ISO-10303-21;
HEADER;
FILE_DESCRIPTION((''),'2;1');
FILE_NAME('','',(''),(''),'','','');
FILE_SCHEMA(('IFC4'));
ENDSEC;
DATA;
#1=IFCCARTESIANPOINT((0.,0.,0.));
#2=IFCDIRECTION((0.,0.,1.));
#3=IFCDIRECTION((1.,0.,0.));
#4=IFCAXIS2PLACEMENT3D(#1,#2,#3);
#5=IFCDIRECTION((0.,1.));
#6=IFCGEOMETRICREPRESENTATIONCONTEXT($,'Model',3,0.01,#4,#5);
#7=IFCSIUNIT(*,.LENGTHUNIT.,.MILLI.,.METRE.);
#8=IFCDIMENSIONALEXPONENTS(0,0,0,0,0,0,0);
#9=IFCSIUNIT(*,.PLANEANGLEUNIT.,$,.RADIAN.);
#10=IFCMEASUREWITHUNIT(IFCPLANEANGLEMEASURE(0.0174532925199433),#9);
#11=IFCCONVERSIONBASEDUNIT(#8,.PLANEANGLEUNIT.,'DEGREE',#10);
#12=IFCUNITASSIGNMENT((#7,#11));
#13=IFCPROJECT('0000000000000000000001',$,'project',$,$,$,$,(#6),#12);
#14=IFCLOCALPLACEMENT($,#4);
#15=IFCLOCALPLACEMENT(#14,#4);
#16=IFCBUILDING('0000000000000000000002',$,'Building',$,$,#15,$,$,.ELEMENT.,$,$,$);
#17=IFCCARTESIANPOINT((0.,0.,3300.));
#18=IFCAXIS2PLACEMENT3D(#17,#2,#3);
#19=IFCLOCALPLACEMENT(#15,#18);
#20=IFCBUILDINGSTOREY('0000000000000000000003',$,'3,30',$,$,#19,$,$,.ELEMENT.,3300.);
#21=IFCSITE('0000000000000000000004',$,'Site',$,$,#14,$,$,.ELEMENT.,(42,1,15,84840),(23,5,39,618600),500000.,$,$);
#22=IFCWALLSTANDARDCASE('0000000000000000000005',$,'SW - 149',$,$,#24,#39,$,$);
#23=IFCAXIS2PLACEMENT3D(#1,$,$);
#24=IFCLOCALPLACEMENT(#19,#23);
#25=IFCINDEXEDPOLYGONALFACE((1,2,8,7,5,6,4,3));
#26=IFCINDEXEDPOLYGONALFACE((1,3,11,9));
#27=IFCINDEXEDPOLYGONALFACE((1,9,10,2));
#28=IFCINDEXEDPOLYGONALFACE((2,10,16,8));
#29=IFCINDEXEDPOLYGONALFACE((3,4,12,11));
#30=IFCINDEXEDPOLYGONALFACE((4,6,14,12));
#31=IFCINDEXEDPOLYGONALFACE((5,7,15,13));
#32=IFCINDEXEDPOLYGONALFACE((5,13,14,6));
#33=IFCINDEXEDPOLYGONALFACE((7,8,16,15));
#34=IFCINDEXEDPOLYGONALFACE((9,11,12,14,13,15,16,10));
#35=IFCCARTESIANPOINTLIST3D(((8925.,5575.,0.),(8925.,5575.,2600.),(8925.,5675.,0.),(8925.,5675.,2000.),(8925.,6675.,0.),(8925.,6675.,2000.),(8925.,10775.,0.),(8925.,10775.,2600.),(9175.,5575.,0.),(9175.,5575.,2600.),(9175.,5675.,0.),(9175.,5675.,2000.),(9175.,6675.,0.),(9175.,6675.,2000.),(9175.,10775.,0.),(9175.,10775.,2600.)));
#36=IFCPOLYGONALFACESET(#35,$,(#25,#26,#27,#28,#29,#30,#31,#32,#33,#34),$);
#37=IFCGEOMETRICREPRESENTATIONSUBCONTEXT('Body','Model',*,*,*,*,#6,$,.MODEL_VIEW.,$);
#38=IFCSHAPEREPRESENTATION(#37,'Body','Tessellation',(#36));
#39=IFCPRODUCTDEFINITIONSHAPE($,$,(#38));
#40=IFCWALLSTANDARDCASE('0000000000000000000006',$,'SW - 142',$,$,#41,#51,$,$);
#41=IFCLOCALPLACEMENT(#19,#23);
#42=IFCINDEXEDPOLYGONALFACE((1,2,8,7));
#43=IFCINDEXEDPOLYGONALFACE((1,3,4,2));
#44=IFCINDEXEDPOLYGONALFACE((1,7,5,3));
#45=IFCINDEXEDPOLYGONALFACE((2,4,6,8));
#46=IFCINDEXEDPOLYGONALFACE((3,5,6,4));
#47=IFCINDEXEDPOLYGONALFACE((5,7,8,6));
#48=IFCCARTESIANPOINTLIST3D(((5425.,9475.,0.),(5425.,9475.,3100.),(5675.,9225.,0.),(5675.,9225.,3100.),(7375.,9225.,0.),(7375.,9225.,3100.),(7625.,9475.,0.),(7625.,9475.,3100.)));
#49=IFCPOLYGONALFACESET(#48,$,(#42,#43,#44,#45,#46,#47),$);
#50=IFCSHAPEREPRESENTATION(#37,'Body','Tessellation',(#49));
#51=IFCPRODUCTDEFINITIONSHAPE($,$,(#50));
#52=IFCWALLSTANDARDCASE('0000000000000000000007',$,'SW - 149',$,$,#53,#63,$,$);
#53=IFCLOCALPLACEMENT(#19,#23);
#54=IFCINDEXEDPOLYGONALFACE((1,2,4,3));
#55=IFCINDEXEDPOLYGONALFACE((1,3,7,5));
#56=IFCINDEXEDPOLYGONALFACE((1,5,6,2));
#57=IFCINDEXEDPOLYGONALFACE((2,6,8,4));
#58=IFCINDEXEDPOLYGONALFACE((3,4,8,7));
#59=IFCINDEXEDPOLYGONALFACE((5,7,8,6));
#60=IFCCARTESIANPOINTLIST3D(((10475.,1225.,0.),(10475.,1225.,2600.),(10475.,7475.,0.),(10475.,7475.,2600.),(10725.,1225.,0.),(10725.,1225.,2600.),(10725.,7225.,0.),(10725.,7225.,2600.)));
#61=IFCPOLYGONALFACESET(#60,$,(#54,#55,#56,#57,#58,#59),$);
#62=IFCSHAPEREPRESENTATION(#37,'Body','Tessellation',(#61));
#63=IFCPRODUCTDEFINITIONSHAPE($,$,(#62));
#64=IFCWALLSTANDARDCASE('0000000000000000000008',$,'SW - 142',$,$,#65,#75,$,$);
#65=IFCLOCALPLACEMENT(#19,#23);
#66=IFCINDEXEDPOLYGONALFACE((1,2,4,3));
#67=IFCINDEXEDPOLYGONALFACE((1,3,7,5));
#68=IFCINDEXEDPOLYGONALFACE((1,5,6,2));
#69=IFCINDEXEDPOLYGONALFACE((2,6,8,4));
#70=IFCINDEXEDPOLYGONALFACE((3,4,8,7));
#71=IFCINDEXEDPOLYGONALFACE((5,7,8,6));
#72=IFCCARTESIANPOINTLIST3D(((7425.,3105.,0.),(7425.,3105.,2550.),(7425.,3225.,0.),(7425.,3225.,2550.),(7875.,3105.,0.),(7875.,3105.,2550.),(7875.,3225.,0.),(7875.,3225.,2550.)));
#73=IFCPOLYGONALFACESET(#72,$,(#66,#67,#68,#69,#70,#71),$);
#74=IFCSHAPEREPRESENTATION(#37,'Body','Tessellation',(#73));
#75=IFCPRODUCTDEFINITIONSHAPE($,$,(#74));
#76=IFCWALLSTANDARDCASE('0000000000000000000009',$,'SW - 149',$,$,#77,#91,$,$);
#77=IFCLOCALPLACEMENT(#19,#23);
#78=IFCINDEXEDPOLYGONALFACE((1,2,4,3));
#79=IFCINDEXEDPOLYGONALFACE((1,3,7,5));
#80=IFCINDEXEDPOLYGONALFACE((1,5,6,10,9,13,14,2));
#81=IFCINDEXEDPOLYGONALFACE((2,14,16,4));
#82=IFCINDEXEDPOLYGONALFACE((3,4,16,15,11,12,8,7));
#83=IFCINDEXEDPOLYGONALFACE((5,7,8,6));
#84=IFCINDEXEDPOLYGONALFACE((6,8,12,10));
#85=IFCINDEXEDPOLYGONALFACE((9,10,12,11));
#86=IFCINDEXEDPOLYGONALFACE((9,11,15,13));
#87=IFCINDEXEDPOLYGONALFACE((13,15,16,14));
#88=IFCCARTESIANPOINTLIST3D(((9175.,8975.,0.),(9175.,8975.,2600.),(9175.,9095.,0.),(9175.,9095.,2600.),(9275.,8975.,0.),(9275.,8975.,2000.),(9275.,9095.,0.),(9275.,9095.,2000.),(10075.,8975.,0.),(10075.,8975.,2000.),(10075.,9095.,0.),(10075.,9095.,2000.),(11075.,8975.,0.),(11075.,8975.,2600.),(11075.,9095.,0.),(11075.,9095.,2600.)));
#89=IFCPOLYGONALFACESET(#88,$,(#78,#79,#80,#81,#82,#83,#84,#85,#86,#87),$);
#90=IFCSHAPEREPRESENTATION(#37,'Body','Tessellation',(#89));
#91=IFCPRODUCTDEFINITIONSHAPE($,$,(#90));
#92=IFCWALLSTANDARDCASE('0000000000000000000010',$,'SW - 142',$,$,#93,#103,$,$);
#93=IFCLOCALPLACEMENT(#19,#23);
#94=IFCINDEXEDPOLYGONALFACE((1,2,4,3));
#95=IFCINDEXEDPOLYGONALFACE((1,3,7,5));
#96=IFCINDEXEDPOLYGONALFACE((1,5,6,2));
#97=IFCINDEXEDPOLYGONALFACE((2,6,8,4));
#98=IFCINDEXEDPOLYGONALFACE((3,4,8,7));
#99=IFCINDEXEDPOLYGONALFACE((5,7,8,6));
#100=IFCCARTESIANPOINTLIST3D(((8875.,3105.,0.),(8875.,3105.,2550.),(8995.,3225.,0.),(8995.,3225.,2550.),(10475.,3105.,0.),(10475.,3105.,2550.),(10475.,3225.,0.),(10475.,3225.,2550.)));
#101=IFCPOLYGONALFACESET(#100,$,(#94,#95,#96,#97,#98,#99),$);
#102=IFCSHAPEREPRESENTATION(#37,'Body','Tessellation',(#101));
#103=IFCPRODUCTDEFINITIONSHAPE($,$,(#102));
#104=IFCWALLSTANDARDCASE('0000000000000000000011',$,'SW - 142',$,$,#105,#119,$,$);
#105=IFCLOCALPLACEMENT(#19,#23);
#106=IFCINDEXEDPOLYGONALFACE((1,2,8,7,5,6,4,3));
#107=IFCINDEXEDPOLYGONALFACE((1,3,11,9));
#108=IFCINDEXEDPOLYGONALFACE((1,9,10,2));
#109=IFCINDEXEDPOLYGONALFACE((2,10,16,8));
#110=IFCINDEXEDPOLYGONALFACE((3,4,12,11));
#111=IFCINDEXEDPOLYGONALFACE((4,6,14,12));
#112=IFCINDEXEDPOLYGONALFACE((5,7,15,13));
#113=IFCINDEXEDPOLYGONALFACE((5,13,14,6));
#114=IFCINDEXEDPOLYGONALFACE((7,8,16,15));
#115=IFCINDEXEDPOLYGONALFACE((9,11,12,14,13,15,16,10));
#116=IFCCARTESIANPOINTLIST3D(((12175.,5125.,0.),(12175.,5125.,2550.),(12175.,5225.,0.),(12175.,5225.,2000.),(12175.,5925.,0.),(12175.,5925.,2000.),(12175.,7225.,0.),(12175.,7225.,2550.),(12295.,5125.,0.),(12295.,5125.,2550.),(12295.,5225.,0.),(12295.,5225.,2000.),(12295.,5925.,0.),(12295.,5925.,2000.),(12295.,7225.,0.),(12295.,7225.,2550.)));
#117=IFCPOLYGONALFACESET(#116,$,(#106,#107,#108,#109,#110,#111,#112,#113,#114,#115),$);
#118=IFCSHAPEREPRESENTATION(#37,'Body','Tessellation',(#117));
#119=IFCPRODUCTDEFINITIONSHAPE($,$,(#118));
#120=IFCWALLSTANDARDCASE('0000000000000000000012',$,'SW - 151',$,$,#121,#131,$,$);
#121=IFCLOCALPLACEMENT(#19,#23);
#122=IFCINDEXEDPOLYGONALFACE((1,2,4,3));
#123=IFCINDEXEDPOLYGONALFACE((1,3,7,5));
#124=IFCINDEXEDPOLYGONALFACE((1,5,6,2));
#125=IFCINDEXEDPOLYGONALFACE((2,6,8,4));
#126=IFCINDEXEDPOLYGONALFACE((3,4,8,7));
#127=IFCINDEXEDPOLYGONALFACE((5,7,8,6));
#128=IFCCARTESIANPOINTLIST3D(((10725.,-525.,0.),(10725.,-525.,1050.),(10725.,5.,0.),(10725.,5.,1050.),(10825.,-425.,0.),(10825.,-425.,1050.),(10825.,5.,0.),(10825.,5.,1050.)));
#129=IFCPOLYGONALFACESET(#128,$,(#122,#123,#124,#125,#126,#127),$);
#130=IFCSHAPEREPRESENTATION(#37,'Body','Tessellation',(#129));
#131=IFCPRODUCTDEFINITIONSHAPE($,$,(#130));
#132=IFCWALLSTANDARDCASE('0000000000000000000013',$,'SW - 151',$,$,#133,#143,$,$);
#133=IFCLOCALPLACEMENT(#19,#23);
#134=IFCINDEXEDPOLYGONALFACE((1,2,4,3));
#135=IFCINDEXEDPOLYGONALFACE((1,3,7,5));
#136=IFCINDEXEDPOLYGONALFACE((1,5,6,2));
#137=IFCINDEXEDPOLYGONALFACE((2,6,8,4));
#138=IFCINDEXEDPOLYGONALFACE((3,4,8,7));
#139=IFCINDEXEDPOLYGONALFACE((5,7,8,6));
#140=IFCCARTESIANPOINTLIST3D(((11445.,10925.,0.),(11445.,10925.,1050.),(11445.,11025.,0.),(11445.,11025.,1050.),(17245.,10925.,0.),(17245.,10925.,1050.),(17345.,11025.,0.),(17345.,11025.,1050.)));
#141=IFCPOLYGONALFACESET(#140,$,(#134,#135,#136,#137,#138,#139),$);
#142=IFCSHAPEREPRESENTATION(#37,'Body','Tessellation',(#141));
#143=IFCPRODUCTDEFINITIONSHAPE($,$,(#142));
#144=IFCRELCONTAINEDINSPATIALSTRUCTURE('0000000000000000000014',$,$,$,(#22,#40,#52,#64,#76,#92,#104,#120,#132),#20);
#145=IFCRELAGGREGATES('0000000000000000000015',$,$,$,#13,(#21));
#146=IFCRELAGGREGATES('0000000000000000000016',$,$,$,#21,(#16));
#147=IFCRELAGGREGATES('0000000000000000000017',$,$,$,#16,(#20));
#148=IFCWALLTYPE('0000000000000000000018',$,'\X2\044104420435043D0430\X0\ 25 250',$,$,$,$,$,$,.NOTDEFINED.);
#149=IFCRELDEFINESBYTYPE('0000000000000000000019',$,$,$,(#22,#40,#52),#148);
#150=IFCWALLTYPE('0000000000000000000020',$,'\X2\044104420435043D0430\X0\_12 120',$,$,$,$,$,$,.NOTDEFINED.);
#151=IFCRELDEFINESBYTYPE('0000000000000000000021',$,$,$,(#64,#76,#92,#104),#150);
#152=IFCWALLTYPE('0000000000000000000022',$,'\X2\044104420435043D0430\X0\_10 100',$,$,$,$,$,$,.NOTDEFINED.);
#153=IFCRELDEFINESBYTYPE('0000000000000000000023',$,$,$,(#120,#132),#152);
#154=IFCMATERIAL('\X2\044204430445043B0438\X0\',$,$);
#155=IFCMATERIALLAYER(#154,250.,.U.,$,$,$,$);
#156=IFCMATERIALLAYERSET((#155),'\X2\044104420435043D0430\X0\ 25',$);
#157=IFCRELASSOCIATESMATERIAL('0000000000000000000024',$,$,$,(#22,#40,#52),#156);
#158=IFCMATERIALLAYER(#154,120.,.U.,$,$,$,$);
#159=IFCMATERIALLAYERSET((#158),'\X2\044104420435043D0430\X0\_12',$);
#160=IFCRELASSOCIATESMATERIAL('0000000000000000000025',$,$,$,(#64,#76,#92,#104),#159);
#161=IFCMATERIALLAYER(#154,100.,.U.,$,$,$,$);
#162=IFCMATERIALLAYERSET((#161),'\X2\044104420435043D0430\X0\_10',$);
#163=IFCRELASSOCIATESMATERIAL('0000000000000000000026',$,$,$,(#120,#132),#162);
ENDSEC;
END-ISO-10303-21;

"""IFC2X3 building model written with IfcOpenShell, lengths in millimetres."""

from ifc_helpers import new_model, entity, si_unit, converted_unit, direction, frame, origin_with_axes, origin_2d_with_axis, place, context, subcontext, project, spatial, polyline, rectangle, outline, extrude, material, layer, layer_set, layer_usage, type_object, element, save


model = new_model("IFC2X3")

# Units and contexts
model_context = context("Model", 3, precision=0.01, world=origin_with_axes(), true_north=direction((0.0, 1.0)))
body_context = subcontext(model_context, "Body", "Model", "MODEL_VIEW")
ifc_project = project(units=[si_unit("LENGTHUNIT", "METRE", prefix="MILLI"), converted_unit("PLANEANGLEUNIT", "DEGREE", entity("IfcPlaneAngleMeasure", 0.0174532925199433), si_unit("PLANEANGLEUNIT", "RADIAN"), dimensions=[0, 0, 0, 0, 0, 0, 0])], contexts=[model_context])

# Site, building, storey
site_placement = place(None, origin_with_axes())
site = spatial("IfcSite", under=ifc_project, at=site_placement, Name="Site", CompositionType="ELEMENT", RefLatitude=(42, 1, 15, 84840), RefLongitude=(23, 5, 39, 618600), RefElevation=500000.0)
building_placement = place(site_placement, origin_with_axes())
building = spatial("IfcBuilding", under=site, at=building_placement, Name="Building", CompositionType="ELEMENT")
storey_placement = place(building_placement, frame((0.0, 0.0, 3300.0), z_axis=(0.0, 0.0, 1.0), x_axis=(1.0, 0.0, 0.0)))
storey = spatial("IfcBuildingStorey", under=building, at=storey_placement, Name="3,30", CompositionType="ELEMENT", Elevation=3300.0)

# Shared definitions
ifc_material_1 = material(Name="тухли")

# Wall, opening
ifc_layer_1 = layer(ifc_material_1, 250.0, ventilated="UNKNOWN")
ifc_layer_set_1 = layer_set([ifc_layer_1], Name="стена 25")
ifc_layer_usage_1 = layer_usage(ifc_layer_set_1, "AXIS2", "NEGATIVE", 0.0)
wall_type_1 = type_object("IfcWallType", Name="стена 25 250", PredefinedType="NOTDEFINED")
wall_1_placement = place(storey_placement, frame((8925.0, 5575.0, 0.0), z_axis=(0.0, 0.0, 1.0), x_axis=(0.0, 1.0, 0.0)))
wall_1 = element("IfcWallStandardCase", 1, at=wall_1_placement, inside=storey, type_object=wall_type_1, material=ifc_layer_usage_1, Name="SW - 149", context=body_context, shape_type="SweptSolid", body=[
    extrude(outline(polyline([(0.0, -250.0), (5200.0, -250.0), (5200.0, 0.0), (0.0, 0.0), (0.0, -250.0)])), origin_with_axes(), (0.0, 0.0, 1.0), 2600.0),
])
opening_1_placement = place(wall_1_placement, frame((600.0, 0.0, 0.0), z_axis=(0.0, 0.0, 1.0), x_axis=(1.0, 0.0, 0.0)))
element("IfcOpeningElement", 2, at=opening_1_placement, cuts=wall_1, context=body_context, shape_type="SweptSolid", body=[
    extrude(rectangle(XDim=1000.0, YDim=2000.0, at=origin_2d_with_axis()), frame((0.0, -250.0, 1000.0), z_axis=(0.0, -1.0, 0.0), x_axis=(-1.0, 0.0, 0.0)), (0.0, 0.0, -1.0), 750.0),
])

# Walls
ifc_layer_usage_2 = layer_usage(ifc_layer_set_1, "AXIS2", "POSITIVE", 0.0)
wall_2_placement = place(storey_placement, frame((7625.0, 9475.0, 0.0), z_axis=(0.0, 0.0, 1.0), x_axis=(-1.0, 0.0, 0.0)))
element("IfcWallStandardCase", 3, at=wall_2_placement, inside=storey, type_object=wall_type_1, material=ifc_layer_usage_2, Name="SW - 142", context=body_context, shape_type="SweptSolid", body=[
    extrude(outline(polyline([(0.0, 0.0), (2200.0, 0.0), (1950.0, 250.0), (250.0, 250.0), (0.0, 0.0)])), origin_with_axes(), (0.0, 0.0, 1.0), 3100.0),
])
ifc_layer_usage_3 = layer_usage(ifc_layer_set_1, "AXIS2", "NEGATIVE", 0.0)
wall_3_placement = place(storey_placement, frame((10475.0, 1225.0, 0.0), z_axis=(0.0, 0.0, 1.0), x_axis=(0.0, 1.0, 0.0)))
element("IfcWallStandardCase", 4, at=wall_3_placement, inside=storey, type_object=wall_type_1, material=ifc_layer_usage_3, Name="SW - 149", context=body_context, shape_type="SweptSolid", body=[
    extrude(outline(polyline([(0.0, -250.0), (6000.0, -250.0), (6250.0, 0.0), (0.0, 0.0), (0.0, -250.0)])), origin_with_axes(), (0.0, 0.0, 1.0), 2600.0),
])
ifc_layer_2 = layer(ifc_material_1, 120.0, ventilated="UNKNOWN")
ifc_layer_set_2 = layer_set([ifc_layer_2], Name="стена_12")
ifc_layer_usage_4 = layer_usage(ifc_layer_set_2, "AXIS2", "POSITIVE", -60.0)
wall_type_2 = type_object("IfcWallType", Name="стена_12 120", PredefinedType="NOTDEFINED")
wall_4_placement = place(storey_placement, frame((7875.0, 3165.0, 0.0), z_axis=(0.0, 0.0, 1.0), x_axis=(-1.0, 0.0, 0.0)))
element("IfcWallStandardCase", 5, at=wall_4_placement, inside=storey, type_object=wall_type_2, material=ifc_layer_usage_4, Name="SW - 142", context=body_context, shape_type="SweptSolid", body=[
    extrude(outline(polyline([(0.0, -60.0), (450.0, -60.0), (450.0, 60.0), (0.0, 60.0), (0.0, -60.0)])), origin_with_axes(), (0.0, 0.0, 1.0), 2550.0),
])

# Wall, opening
ifc_layer_usage_5 = layer_usage(ifc_layer_set_2, "AXIS2", "NEGATIVE", 0.0)
wall_5_placement = place(storey_placement, frame((11075.0, 8975.0, 0.0), z_axis=(0.0, 0.0, 1.0), x_axis=(-1.0, 0.0, 0.0)))
wall_5 = element("IfcWallStandardCase", 6, at=wall_5_placement, inside=storey, type_object=wall_type_2, material=ifc_layer_usage_5, Name="SW - 149", context=body_context, shape_type="SweptSolid", body=[
    extrude(outline(polyline([(0.0, -120.0), (1900.0, -120.0), (1900.0, 0.0), (0.0, 0.0), (0.0, -120.0)])), origin_with_axes(), (0.0, 0.0, 1.0), 2600.0),
])
opening_2_placement = place(wall_5_placement, frame((1400.0, 0.0, 0.0), z_axis=(0.0, 0.0, 1.0), x_axis=(1.0, 0.0, 0.0)))
element("IfcOpeningElement", 7, at=opening_2_placement, cuts=wall_5, context=body_context, shape_type="SweptSolid", body=[
    extrude(rectangle(XDim=800.0, YDim=2000.0, at=origin_2d_with_axis()), frame((0.0, 120.0, 1000.0), z_axis=(0.0, 1.0, 0.0), x_axis=(1.0, 0.0, 0.0)), (0.0, 0.0, -1.0), 360.0),
])

# Wall
ifc_layer_usage_6 = layer_usage(ifc_layer_set_2, "AXIS2", "POSITIVE", -60.0)
wall_6_placement = place(storey_placement, frame((10475.0, 3165.0, 0.0), z_axis=(0.0, 0.0, 1.0), x_axis=(-1.0, 0.0, 0.0)))
element("IfcWallStandardCase", 8, at=wall_6_placement, inside=storey, type_object=wall_type_2, material=ifc_layer_usage_6, Name="SW - 142", context=body_context, shape_type="SweptSolid", body=[
    extrude(outline(polyline([(0.0, -60.0), (1480.0, -60.0), (1600.0, 60.0), (0.0, 60.0), (0.0, -60.0)])), origin_with_axes(), (0.0, 0.0, 1.0), 2550.0),
])

# Wall, opening
ifc_layer_usage_7 = layer_usage(ifc_layer_set_2, "AXIS2", "POSITIVE", -60.0)
wall_7_placement = place(storey_placement, frame((12235.0, 7225.0, 0.0), z_axis=(0.0, 0.0, 1.0), x_axis=(0.0, -1.0, 0.0)))
wall_7 = element("IfcWallStandardCase", 9, at=wall_7_placement, inside=storey, type_object=wall_type_2, material=ifc_layer_usage_7, Name="SW - 142", context=body_context, shape_type="SweptSolid", body=[
    extrude(outline(polyline([(0.0, -60.0), (2100.0, -60.0), (2100.0, 60.0), (0.0, 60.0), (0.0, -60.0)])), origin_with_axes(), (0.0, 0.0, 1.0), 2550.0),
])
opening_3_placement = place(wall_7_placement, frame((1650.0, 0.0, 0.0), z_axis=(0.0, 0.0, 1.0), x_axis=(1.0, 0.0, 0.0)))
element("IfcOpeningElement", 10, at=opening_3_placement, cuts=wall_7, context=body_context, shape_type="SweptSolid", body=[
    extrude(rectangle(XDim=700.0, YDim=2000.0, at=origin_2d_with_axis()), frame((0.0, -120.0, 1000.0), z_axis=(0.0, 1.0, 0.0), x_axis=(1.0, 0.0, 0.0)), (0.0, 0.0, 1.0), 360.0),
])

# Walls
ifc_layer_3 = layer(ifc_material_1, 100.0, ventilated="UNKNOWN")
ifc_layer_set_3 = layer_set([ifc_layer_3], Name="стена_10")
ifc_layer_usage_8 = layer_usage(ifc_layer_set_3, "AXIS2", "NEGATIVE", 0.0)
wall_type_3 = type_object("IfcWallType", Name="стена_10 100", PredefinedType="NOTDEFINED")
wall_8_placement = place(storey_placement, frame((10725.0, -525.0, 0.0), z_axis=(0.0, 0.0, 1.0), x_axis=(0.0, 1.0, 0.0)))
element("IfcWallStandardCase", 11, at=wall_8_placement, inside=storey, type_object=wall_type_3, material=ifc_layer_usage_8, Name="SW - 151", context=body_context, shape_type="SweptSolid", body=[
    extrude(outline(polyline([(100.0, -100.0), (530.0, -100.0), (530.0, 0.0), (0.0, 0.0), (100.0, -100.0)])), origin_with_axes(), (0.0, 0.0, 1.0), 1050.0),
])
ifc_layer_usage_9 = layer_usage(ifc_layer_set_3, "AXIS2", "NEGATIVE", 0.0)
wall_9_placement = place(storey_placement, frame((11445.0, 11025.0, 0.0), z_axis=(0.0, 0.0, 1.0), x_axis=(1.0, 0.0, 0.0)))
element("IfcWallStandardCase", 12, at=wall_9_placement, inside=storey, type_object=wall_type_3, material=ifc_layer_usage_9, Name="SW - 151", context=body_context, shape_type="SweptSolid", body=[
    extrude(outline(polyline([(0.0, -100.0), (5800.0, -100.0), (5900.0, 0.0), (0.0, 0.0), (0.0, -100.0)])), origin_with_axes(), (0.0, 0.0, 1.0), 1050.0),
])

save(model, "model.ifc")
